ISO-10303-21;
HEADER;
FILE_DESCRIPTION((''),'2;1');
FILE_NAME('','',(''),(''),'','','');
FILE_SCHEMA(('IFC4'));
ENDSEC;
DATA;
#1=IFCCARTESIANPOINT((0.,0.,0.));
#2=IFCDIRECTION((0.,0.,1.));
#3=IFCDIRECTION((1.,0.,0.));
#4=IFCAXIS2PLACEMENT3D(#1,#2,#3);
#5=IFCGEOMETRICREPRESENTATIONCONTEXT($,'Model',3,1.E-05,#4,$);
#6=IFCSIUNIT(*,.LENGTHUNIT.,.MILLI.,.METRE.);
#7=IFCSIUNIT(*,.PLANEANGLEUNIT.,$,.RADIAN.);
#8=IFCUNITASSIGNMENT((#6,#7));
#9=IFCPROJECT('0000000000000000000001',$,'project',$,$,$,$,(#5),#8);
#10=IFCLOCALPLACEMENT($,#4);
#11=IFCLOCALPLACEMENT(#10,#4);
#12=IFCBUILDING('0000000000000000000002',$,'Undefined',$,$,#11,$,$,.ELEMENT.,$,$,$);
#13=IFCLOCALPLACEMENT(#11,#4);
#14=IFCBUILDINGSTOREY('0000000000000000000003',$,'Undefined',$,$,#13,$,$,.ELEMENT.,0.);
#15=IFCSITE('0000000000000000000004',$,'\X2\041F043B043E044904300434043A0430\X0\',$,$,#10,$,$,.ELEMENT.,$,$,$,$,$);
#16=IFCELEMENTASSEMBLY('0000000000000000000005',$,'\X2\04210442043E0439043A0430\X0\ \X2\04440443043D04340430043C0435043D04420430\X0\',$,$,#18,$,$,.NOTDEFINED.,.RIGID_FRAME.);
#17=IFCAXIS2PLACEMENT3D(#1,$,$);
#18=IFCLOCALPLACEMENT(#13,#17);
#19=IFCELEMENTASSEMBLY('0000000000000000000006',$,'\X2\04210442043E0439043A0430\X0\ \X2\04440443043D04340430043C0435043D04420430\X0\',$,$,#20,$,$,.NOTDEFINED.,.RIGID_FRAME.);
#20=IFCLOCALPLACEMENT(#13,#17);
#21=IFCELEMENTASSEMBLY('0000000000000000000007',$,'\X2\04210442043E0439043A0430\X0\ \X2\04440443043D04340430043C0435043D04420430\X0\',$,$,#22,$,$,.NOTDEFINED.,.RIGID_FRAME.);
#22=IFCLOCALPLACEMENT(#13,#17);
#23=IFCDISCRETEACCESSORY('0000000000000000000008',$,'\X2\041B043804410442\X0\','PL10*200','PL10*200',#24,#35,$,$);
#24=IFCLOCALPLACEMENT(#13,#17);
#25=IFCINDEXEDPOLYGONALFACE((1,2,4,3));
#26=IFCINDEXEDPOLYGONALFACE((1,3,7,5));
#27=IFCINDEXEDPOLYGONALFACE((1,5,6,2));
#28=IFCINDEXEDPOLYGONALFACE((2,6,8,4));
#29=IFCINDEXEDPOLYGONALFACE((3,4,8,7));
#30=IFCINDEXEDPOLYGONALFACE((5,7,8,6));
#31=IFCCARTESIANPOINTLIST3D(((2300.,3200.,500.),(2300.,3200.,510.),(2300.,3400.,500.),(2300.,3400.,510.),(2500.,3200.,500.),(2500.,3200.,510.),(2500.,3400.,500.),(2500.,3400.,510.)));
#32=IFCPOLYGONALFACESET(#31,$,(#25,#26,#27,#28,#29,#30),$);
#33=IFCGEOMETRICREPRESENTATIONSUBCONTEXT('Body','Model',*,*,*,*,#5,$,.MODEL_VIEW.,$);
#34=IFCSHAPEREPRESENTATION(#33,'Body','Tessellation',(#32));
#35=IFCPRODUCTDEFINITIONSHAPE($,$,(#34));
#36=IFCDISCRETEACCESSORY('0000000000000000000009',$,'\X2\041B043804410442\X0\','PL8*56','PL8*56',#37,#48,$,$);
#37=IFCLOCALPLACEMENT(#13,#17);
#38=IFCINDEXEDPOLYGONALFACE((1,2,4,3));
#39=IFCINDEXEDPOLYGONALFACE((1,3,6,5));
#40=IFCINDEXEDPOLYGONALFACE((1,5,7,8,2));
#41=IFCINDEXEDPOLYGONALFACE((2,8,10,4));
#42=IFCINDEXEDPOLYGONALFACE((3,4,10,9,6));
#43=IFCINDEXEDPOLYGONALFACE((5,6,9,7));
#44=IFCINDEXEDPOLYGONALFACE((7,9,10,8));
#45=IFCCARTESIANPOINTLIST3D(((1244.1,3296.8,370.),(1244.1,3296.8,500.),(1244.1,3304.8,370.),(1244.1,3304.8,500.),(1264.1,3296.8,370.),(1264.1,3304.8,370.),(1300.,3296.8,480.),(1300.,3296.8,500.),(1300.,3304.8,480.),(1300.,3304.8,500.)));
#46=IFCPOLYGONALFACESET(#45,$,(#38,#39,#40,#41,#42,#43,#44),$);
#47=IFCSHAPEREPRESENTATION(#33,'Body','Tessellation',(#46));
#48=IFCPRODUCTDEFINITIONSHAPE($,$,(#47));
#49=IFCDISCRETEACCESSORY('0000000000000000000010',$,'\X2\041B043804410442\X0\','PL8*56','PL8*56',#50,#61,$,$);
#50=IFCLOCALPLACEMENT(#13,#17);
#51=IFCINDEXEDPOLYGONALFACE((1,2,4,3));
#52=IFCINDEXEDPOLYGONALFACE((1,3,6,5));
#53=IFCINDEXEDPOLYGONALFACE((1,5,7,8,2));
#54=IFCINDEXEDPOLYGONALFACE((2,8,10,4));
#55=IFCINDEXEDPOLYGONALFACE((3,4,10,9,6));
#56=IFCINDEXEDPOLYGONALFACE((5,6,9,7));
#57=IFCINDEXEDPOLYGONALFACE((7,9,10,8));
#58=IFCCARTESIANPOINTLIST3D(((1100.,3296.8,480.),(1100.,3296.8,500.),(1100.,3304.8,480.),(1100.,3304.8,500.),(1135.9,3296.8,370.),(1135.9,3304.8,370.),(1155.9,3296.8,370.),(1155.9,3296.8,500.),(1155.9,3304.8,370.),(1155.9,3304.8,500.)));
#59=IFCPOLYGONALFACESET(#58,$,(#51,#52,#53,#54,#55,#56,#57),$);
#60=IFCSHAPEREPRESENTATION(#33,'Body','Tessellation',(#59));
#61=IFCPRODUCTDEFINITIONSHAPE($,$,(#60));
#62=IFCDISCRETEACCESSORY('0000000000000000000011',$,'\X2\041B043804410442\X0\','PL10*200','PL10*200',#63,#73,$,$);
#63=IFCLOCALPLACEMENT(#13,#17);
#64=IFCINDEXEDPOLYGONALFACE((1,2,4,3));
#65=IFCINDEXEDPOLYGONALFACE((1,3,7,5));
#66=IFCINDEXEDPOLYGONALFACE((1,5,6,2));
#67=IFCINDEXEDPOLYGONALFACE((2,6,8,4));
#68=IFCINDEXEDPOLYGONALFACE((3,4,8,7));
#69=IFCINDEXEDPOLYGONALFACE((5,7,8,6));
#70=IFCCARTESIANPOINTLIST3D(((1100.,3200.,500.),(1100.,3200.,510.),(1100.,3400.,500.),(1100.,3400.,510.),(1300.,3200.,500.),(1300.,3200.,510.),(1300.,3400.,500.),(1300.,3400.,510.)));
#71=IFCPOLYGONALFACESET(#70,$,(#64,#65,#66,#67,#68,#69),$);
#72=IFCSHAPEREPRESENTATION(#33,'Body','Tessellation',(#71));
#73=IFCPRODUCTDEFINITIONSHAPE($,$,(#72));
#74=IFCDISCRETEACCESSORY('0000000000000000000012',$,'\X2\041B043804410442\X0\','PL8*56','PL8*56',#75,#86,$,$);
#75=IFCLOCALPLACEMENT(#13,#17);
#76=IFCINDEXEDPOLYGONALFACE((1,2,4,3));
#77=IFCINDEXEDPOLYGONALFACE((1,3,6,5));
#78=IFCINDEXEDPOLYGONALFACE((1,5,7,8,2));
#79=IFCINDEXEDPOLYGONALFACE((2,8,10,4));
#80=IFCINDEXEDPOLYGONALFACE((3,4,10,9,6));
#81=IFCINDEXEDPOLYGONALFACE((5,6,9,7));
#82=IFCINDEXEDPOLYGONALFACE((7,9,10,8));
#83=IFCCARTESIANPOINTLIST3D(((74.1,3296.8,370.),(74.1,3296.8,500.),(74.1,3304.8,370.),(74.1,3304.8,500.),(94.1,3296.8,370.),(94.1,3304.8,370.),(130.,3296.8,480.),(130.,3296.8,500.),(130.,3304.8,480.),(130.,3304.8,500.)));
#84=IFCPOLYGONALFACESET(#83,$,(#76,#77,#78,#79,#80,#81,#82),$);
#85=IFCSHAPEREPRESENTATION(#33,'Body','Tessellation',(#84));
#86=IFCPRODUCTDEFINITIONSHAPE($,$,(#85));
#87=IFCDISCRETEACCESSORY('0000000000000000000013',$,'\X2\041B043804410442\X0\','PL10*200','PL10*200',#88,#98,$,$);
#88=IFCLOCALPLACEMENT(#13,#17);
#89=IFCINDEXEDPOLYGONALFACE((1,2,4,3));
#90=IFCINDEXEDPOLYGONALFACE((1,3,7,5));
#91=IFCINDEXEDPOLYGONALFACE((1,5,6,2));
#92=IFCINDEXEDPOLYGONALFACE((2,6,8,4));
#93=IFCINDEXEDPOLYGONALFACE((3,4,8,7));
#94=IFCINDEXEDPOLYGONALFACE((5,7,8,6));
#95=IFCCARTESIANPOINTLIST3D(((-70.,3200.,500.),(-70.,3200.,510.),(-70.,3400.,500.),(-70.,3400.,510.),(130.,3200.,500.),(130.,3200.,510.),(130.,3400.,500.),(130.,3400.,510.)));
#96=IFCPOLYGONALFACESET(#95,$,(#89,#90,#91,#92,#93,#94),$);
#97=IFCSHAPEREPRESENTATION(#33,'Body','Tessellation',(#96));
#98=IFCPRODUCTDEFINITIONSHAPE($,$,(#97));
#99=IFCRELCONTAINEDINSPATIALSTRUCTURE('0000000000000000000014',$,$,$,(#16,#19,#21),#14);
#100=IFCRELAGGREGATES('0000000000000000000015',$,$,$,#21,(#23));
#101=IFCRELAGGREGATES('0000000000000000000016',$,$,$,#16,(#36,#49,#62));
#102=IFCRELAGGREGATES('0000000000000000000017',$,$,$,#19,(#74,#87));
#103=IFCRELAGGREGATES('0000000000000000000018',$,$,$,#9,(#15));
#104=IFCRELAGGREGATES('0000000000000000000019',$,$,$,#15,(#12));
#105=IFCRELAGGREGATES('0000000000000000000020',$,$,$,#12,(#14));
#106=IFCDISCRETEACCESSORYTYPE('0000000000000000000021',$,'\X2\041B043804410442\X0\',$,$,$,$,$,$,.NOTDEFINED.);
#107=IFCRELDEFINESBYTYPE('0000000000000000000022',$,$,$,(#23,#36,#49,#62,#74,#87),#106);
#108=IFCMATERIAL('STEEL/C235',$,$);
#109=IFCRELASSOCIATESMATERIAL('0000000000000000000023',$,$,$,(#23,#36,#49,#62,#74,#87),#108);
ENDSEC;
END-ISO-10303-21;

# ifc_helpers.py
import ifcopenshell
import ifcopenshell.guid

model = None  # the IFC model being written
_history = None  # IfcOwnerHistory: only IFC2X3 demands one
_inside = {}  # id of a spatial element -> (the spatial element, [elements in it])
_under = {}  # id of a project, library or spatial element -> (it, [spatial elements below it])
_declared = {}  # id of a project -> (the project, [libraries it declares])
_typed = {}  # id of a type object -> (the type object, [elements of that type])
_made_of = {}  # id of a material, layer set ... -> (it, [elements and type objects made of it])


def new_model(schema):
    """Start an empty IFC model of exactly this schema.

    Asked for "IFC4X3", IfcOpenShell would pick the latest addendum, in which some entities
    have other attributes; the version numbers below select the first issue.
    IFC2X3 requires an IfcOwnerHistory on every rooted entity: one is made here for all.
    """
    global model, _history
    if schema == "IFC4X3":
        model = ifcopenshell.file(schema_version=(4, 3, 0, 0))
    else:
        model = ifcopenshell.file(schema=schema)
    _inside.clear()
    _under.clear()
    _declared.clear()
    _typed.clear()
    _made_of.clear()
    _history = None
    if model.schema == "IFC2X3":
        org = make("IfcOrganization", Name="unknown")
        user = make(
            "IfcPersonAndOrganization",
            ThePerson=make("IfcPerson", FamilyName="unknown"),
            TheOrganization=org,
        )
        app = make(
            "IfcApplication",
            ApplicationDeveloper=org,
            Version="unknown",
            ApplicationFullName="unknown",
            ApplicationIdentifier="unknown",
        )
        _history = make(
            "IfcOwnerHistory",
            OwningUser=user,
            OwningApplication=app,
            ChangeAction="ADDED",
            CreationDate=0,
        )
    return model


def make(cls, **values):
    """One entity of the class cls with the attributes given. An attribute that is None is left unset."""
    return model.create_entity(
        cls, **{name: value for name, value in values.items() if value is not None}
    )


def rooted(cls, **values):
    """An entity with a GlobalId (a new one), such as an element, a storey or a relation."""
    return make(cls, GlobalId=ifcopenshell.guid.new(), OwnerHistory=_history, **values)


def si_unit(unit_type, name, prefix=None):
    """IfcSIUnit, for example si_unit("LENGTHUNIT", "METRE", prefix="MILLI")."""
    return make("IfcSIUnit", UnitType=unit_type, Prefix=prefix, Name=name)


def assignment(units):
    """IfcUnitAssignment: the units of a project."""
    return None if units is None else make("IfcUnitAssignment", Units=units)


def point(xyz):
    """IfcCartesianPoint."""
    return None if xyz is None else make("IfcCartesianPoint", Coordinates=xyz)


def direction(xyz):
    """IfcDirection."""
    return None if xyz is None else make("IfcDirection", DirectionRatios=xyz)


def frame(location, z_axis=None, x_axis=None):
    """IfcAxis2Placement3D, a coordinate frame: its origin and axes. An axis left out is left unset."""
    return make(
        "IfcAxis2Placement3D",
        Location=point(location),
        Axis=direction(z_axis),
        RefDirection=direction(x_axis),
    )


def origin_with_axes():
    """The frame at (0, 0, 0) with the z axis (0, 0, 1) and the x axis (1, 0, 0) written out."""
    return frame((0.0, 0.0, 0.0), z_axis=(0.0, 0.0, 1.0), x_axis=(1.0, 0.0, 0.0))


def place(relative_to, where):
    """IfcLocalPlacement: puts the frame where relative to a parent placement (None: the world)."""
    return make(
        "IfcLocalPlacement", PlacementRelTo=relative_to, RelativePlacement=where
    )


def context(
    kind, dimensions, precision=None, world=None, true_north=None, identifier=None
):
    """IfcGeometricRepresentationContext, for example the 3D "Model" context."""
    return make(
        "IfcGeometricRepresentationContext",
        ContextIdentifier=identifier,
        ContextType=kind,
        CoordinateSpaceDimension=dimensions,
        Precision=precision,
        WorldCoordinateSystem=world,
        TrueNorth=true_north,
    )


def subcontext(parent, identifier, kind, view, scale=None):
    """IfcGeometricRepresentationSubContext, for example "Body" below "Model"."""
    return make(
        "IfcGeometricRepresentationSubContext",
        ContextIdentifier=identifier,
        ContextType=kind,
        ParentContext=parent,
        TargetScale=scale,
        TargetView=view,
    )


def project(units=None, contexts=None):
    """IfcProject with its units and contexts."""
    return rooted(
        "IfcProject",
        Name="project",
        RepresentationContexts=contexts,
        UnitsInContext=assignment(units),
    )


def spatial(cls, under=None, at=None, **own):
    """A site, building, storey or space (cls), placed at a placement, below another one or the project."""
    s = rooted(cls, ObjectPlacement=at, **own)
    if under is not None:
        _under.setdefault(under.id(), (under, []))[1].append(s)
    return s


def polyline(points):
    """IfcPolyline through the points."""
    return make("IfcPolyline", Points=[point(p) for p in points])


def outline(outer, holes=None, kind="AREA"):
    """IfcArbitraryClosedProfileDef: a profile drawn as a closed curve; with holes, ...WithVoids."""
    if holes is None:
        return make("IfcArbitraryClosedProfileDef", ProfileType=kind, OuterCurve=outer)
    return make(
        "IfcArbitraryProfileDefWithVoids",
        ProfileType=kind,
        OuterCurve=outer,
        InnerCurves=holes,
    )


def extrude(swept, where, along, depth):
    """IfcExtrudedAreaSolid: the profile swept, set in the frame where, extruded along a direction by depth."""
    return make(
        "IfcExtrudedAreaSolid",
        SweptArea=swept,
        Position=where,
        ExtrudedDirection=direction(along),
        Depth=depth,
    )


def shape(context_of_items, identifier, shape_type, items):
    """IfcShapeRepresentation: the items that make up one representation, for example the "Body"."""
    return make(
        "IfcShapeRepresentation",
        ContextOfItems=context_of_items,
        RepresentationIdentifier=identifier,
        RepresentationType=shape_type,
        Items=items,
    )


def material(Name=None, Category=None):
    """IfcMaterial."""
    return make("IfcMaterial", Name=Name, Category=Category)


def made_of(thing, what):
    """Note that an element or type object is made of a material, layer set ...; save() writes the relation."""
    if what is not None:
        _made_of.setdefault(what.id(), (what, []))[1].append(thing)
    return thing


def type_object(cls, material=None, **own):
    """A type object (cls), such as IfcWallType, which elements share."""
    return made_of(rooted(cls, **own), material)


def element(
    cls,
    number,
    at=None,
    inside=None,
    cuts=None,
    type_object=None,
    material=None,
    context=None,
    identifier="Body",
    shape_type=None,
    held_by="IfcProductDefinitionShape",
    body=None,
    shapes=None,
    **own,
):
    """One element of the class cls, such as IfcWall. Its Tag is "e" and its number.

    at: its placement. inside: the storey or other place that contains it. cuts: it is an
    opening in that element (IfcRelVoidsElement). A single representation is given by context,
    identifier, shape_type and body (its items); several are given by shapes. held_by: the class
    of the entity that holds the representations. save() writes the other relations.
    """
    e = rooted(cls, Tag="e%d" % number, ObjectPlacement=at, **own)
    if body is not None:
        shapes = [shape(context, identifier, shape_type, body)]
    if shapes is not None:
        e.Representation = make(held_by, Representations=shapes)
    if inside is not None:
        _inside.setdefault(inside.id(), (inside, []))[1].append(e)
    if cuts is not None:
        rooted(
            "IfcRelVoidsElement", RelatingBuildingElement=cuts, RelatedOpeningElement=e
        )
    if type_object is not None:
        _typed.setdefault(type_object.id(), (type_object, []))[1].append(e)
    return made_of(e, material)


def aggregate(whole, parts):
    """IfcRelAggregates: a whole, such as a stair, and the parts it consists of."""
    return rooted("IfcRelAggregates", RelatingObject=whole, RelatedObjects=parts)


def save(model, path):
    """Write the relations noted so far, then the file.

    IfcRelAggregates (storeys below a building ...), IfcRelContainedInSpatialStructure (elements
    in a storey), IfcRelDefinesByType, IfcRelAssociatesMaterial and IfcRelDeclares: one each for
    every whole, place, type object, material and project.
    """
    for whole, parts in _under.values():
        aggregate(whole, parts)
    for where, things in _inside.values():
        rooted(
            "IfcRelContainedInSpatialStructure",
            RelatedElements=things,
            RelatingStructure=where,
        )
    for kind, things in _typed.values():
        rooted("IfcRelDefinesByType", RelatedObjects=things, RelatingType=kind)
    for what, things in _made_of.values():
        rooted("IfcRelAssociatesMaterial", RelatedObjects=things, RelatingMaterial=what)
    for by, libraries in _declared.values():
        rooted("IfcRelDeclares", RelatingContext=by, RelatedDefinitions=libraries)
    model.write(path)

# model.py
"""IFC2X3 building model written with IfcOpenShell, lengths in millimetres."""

from ifc_helpers import new_model, si_unit, frame, origin_with_axes, place, context, subcontext, project, spatial, polyline, outline, extrude, material, type_object, element, aggregate, save


model = new_model("IFC2X3")

# Units and contexts
model_context = context("Model", 3, precision=1e-05, world=origin_with_axes())
body_context = subcontext(model_context, "Body", "Model", "MODEL_VIEW")
ifc_project = project(units=[si_unit("LENGTHUNIT", "METRE", prefix="MILLI"), si_unit("PLANEANGLEUNIT", "RADIAN")], contexts=[model_context])

# Site, building, storey
site_placement = place(None, origin_with_axes())
site = spatial("IfcSite", under=ifc_project, at=site_placement, Name="Площадка", CompositionType="ELEMENT")
building_placement = place(site_placement, origin_with_axes())
building = spatial("IfcBuilding", under=site, at=building_placement, Name="Undefined", CompositionType="ELEMENT")
storey_placement = place(building_placement, origin_with_axes())
storey = spatial("IfcBuildingStorey", under=building, at=storey_placement, Name="Undefined", CompositionType="ELEMENT", Elevation=0.0)

# Element assemblies
assembly_1_placement = place(storey_placement, origin_with_axes())
assembly_1 = element("IfcElementAssembly", 1, at=assembly_1_placement, inside=storey, Name="Стойка фундамента", AssemblyPlace="NOTDEFINED", PredefinedType="RIGID_FRAME")
ifc_material_1 = material(Name="STEEL/C235")
assembly_2_placement = place(storey_placement, origin_with_axes())
assembly_2 = element("IfcElementAssembly", 2, at=assembly_2_placement, inside=storey, Name="Стойка фундамента", AssemblyPlace="NOTDEFINED", PredefinedType="RIGID_FRAME")

# Element assembly, discrete accessory
assembly_3_placement = place(storey_placement, origin_with_axes())
assembly_3 = element("IfcElementAssembly", 3, at=assembly_3_placement, inside=storey, Name="Стойка фундамента", AssemblyPlace="NOTDEFINED", PredefinedType="RIGID_FRAME")
discrete_accessory_type = type_object("IfcDiscreteAccessoryType", Name="Лист")
discrete_accessory_1_placement = place(assembly_3_placement, frame((2300.0, 3400.0, 505.0), z_axis=(0.0, 0.0, -1.0), x_axis=(1.0, 0.0, 0.0)))
discrete_accessory_1 = element("IfcDiscreteAccessory", 4, at=discrete_accessory_1_placement, type_object=discrete_accessory_type, material=ifc_material_1, Name="Лист", Description="PL10*200", ObjectType="PL10*200", context=body_context, shape_type="SweptSolid", body=[
    extrude(outline(polyline([(0.0, 0.0), (200.0, 0.0), (200.0, 200.0), (0.0, 200.0), (0.0, 0.0)])), frame((0.0, 0.0, -5.0), z_axis=(0.0, 0.0, 1.0), x_axis=(1.0, 0.0, 0.0)), (0.0, 0.0, 1.0), 10.0),
])
aggregate(assembly_3, [discrete_accessory_1])

# Discrete accessories
discrete_accessory_2_placement = place(assembly_1_placement, frame((1244.1, 3300.8, 500.0), z_axis=(0.0, 1.0, 0.0), x_axis=(1.0, 0.0, 0.0)))
discrete_accessory_2 = element("IfcDiscreteAccessory", 5, at=discrete_accessory_2_placement, type_object=discrete_accessory_type, material=ifc_material_1, Name="Лист", Description="PL8*56", ObjectType="PL8*56", context=body_context, shape_type="SweptSolid", body=[
    extrude(outline(polyline([(0.0, 0.0), (55.9, 0.0), (55.9, 20.0), (20.0, 130.0), (0.0, 130.0), (0.0, 0.0)])), frame((0.0, 0.0, -4.0), z_axis=(0.0, 0.0, 1.0), x_axis=(1.0, 0.0, 0.0)), (0.0, 0.0, 1.0), 8.0),
])
discrete_accessory_3_placement = place(assembly_1_placement, frame((1155.9, 3300.8, 500.0), z_axis=(0.0, -1.0, 0.0), x_axis=(-1.0, 0.0, 0.0)))
discrete_accessory_3 = element("IfcDiscreteAccessory", 6, at=discrete_accessory_3_placement, type_object=discrete_accessory_type, material=ifc_material_1, Name="Лист", Description="PL8*56", ObjectType="PL8*56", context=body_context, shape_type="SweptSolid", body=[
    extrude(outline(polyline([(0.0, 0.0), (55.9, 0.0), (55.9, 20.0), (20.0, 130.0), (0.0, 130.0), (0.0, 0.0)])), frame((0.0, 0.0, -4.0), z_axis=(0.0, 0.0, 1.0), x_axis=(1.0, 0.0, 0.0)), (0.0, 0.0, 1.0), 8.0),
])
discrete_accessory_4_placement = place(assembly_1_placement, frame((1100.0, 3400.0, 505.0), z_axis=(0.0, 0.0, -1.0), x_axis=(1.0, 0.0, 0.0)))
discrete_accessory_4 = element("IfcDiscreteAccessory", 7, at=discrete_accessory_4_placement, type_object=discrete_accessory_type, material=ifc_material_1, Name="Лист", Description="PL10*200", ObjectType="PL10*200", context=body_context, shape_type="SweptSolid", body=[
    extrude(outline(polyline([(0.0, 0.0), (200.0, 0.0), (200.0, 200.0), (0.0, 200.0), (0.0, 0.0)])), frame((0.0, 0.0, -5.0), z_axis=(0.0, 0.0, 1.0), x_axis=(1.0, 0.0, 0.0)), (0.0, 0.0, 1.0), 10.0),
])
aggregate(assembly_1, [discrete_accessory_2, discrete_accessory_3, discrete_accessory_4])
discrete_accessory_5_placement = place(assembly_2_placement, frame((74.1, 3300.8, 500.0), z_axis=(0.0, 1.0, 0.0), x_axis=(1.0, 0.0, 0.0)))
discrete_accessory_5 = element("IfcDiscreteAccessory", 8, at=discrete_accessory_5_placement, type_object=discrete_accessory_type, material=ifc_material_1, Name="Лист", Description="PL8*56", ObjectType="PL8*56", context=body_context, shape_type="SweptSolid", body=[
    extrude(outline(polyline([(0.0, 0.0), (55.9, 0.0), (55.9, 20.0), (20.0, 130.0), (0.0, 130.0), (0.0, 0.0)])), frame((0.0, 0.0, -4.0), z_axis=(0.0, 0.0, 1.0), x_axis=(1.0, 0.0, 0.0)), (0.0, 0.0, 1.0), 8.0),
])
discrete_accessory_6_placement = place(assembly_2_placement, frame((130.0, 3400.0, 505.0), z_axis=(0.0, 0.0, 1.0), x_axis=(-1.0, 0.0, 0.0)))
discrete_accessory_6 = element("IfcDiscreteAccessory", 9, at=discrete_accessory_6_placement, type_object=discrete_accessory_type, material=ifc_material_1, Name="Лист", Description="PL10*200", ObjectType="PL10*200", context=body_context, shape_type="SweptSolid", body=[
    extrude(outline(polyline([(0.0, 0.0), (200.0, 0.0), (200.0, 200.0), (0.0, 200.0), (0.0, 0.0)])), frame((0.0, 0.0, -5.0), z_axis=(0.0, 0.0, 1.0), x_axis=(1.0, 0.0, 0.0)), (0.0, 0.0, 1.0), 10.0),
])
aggregate(assembly_2, [discrete_accessory_5, discrete_accessory_6])

save(model, "model.ifc")
